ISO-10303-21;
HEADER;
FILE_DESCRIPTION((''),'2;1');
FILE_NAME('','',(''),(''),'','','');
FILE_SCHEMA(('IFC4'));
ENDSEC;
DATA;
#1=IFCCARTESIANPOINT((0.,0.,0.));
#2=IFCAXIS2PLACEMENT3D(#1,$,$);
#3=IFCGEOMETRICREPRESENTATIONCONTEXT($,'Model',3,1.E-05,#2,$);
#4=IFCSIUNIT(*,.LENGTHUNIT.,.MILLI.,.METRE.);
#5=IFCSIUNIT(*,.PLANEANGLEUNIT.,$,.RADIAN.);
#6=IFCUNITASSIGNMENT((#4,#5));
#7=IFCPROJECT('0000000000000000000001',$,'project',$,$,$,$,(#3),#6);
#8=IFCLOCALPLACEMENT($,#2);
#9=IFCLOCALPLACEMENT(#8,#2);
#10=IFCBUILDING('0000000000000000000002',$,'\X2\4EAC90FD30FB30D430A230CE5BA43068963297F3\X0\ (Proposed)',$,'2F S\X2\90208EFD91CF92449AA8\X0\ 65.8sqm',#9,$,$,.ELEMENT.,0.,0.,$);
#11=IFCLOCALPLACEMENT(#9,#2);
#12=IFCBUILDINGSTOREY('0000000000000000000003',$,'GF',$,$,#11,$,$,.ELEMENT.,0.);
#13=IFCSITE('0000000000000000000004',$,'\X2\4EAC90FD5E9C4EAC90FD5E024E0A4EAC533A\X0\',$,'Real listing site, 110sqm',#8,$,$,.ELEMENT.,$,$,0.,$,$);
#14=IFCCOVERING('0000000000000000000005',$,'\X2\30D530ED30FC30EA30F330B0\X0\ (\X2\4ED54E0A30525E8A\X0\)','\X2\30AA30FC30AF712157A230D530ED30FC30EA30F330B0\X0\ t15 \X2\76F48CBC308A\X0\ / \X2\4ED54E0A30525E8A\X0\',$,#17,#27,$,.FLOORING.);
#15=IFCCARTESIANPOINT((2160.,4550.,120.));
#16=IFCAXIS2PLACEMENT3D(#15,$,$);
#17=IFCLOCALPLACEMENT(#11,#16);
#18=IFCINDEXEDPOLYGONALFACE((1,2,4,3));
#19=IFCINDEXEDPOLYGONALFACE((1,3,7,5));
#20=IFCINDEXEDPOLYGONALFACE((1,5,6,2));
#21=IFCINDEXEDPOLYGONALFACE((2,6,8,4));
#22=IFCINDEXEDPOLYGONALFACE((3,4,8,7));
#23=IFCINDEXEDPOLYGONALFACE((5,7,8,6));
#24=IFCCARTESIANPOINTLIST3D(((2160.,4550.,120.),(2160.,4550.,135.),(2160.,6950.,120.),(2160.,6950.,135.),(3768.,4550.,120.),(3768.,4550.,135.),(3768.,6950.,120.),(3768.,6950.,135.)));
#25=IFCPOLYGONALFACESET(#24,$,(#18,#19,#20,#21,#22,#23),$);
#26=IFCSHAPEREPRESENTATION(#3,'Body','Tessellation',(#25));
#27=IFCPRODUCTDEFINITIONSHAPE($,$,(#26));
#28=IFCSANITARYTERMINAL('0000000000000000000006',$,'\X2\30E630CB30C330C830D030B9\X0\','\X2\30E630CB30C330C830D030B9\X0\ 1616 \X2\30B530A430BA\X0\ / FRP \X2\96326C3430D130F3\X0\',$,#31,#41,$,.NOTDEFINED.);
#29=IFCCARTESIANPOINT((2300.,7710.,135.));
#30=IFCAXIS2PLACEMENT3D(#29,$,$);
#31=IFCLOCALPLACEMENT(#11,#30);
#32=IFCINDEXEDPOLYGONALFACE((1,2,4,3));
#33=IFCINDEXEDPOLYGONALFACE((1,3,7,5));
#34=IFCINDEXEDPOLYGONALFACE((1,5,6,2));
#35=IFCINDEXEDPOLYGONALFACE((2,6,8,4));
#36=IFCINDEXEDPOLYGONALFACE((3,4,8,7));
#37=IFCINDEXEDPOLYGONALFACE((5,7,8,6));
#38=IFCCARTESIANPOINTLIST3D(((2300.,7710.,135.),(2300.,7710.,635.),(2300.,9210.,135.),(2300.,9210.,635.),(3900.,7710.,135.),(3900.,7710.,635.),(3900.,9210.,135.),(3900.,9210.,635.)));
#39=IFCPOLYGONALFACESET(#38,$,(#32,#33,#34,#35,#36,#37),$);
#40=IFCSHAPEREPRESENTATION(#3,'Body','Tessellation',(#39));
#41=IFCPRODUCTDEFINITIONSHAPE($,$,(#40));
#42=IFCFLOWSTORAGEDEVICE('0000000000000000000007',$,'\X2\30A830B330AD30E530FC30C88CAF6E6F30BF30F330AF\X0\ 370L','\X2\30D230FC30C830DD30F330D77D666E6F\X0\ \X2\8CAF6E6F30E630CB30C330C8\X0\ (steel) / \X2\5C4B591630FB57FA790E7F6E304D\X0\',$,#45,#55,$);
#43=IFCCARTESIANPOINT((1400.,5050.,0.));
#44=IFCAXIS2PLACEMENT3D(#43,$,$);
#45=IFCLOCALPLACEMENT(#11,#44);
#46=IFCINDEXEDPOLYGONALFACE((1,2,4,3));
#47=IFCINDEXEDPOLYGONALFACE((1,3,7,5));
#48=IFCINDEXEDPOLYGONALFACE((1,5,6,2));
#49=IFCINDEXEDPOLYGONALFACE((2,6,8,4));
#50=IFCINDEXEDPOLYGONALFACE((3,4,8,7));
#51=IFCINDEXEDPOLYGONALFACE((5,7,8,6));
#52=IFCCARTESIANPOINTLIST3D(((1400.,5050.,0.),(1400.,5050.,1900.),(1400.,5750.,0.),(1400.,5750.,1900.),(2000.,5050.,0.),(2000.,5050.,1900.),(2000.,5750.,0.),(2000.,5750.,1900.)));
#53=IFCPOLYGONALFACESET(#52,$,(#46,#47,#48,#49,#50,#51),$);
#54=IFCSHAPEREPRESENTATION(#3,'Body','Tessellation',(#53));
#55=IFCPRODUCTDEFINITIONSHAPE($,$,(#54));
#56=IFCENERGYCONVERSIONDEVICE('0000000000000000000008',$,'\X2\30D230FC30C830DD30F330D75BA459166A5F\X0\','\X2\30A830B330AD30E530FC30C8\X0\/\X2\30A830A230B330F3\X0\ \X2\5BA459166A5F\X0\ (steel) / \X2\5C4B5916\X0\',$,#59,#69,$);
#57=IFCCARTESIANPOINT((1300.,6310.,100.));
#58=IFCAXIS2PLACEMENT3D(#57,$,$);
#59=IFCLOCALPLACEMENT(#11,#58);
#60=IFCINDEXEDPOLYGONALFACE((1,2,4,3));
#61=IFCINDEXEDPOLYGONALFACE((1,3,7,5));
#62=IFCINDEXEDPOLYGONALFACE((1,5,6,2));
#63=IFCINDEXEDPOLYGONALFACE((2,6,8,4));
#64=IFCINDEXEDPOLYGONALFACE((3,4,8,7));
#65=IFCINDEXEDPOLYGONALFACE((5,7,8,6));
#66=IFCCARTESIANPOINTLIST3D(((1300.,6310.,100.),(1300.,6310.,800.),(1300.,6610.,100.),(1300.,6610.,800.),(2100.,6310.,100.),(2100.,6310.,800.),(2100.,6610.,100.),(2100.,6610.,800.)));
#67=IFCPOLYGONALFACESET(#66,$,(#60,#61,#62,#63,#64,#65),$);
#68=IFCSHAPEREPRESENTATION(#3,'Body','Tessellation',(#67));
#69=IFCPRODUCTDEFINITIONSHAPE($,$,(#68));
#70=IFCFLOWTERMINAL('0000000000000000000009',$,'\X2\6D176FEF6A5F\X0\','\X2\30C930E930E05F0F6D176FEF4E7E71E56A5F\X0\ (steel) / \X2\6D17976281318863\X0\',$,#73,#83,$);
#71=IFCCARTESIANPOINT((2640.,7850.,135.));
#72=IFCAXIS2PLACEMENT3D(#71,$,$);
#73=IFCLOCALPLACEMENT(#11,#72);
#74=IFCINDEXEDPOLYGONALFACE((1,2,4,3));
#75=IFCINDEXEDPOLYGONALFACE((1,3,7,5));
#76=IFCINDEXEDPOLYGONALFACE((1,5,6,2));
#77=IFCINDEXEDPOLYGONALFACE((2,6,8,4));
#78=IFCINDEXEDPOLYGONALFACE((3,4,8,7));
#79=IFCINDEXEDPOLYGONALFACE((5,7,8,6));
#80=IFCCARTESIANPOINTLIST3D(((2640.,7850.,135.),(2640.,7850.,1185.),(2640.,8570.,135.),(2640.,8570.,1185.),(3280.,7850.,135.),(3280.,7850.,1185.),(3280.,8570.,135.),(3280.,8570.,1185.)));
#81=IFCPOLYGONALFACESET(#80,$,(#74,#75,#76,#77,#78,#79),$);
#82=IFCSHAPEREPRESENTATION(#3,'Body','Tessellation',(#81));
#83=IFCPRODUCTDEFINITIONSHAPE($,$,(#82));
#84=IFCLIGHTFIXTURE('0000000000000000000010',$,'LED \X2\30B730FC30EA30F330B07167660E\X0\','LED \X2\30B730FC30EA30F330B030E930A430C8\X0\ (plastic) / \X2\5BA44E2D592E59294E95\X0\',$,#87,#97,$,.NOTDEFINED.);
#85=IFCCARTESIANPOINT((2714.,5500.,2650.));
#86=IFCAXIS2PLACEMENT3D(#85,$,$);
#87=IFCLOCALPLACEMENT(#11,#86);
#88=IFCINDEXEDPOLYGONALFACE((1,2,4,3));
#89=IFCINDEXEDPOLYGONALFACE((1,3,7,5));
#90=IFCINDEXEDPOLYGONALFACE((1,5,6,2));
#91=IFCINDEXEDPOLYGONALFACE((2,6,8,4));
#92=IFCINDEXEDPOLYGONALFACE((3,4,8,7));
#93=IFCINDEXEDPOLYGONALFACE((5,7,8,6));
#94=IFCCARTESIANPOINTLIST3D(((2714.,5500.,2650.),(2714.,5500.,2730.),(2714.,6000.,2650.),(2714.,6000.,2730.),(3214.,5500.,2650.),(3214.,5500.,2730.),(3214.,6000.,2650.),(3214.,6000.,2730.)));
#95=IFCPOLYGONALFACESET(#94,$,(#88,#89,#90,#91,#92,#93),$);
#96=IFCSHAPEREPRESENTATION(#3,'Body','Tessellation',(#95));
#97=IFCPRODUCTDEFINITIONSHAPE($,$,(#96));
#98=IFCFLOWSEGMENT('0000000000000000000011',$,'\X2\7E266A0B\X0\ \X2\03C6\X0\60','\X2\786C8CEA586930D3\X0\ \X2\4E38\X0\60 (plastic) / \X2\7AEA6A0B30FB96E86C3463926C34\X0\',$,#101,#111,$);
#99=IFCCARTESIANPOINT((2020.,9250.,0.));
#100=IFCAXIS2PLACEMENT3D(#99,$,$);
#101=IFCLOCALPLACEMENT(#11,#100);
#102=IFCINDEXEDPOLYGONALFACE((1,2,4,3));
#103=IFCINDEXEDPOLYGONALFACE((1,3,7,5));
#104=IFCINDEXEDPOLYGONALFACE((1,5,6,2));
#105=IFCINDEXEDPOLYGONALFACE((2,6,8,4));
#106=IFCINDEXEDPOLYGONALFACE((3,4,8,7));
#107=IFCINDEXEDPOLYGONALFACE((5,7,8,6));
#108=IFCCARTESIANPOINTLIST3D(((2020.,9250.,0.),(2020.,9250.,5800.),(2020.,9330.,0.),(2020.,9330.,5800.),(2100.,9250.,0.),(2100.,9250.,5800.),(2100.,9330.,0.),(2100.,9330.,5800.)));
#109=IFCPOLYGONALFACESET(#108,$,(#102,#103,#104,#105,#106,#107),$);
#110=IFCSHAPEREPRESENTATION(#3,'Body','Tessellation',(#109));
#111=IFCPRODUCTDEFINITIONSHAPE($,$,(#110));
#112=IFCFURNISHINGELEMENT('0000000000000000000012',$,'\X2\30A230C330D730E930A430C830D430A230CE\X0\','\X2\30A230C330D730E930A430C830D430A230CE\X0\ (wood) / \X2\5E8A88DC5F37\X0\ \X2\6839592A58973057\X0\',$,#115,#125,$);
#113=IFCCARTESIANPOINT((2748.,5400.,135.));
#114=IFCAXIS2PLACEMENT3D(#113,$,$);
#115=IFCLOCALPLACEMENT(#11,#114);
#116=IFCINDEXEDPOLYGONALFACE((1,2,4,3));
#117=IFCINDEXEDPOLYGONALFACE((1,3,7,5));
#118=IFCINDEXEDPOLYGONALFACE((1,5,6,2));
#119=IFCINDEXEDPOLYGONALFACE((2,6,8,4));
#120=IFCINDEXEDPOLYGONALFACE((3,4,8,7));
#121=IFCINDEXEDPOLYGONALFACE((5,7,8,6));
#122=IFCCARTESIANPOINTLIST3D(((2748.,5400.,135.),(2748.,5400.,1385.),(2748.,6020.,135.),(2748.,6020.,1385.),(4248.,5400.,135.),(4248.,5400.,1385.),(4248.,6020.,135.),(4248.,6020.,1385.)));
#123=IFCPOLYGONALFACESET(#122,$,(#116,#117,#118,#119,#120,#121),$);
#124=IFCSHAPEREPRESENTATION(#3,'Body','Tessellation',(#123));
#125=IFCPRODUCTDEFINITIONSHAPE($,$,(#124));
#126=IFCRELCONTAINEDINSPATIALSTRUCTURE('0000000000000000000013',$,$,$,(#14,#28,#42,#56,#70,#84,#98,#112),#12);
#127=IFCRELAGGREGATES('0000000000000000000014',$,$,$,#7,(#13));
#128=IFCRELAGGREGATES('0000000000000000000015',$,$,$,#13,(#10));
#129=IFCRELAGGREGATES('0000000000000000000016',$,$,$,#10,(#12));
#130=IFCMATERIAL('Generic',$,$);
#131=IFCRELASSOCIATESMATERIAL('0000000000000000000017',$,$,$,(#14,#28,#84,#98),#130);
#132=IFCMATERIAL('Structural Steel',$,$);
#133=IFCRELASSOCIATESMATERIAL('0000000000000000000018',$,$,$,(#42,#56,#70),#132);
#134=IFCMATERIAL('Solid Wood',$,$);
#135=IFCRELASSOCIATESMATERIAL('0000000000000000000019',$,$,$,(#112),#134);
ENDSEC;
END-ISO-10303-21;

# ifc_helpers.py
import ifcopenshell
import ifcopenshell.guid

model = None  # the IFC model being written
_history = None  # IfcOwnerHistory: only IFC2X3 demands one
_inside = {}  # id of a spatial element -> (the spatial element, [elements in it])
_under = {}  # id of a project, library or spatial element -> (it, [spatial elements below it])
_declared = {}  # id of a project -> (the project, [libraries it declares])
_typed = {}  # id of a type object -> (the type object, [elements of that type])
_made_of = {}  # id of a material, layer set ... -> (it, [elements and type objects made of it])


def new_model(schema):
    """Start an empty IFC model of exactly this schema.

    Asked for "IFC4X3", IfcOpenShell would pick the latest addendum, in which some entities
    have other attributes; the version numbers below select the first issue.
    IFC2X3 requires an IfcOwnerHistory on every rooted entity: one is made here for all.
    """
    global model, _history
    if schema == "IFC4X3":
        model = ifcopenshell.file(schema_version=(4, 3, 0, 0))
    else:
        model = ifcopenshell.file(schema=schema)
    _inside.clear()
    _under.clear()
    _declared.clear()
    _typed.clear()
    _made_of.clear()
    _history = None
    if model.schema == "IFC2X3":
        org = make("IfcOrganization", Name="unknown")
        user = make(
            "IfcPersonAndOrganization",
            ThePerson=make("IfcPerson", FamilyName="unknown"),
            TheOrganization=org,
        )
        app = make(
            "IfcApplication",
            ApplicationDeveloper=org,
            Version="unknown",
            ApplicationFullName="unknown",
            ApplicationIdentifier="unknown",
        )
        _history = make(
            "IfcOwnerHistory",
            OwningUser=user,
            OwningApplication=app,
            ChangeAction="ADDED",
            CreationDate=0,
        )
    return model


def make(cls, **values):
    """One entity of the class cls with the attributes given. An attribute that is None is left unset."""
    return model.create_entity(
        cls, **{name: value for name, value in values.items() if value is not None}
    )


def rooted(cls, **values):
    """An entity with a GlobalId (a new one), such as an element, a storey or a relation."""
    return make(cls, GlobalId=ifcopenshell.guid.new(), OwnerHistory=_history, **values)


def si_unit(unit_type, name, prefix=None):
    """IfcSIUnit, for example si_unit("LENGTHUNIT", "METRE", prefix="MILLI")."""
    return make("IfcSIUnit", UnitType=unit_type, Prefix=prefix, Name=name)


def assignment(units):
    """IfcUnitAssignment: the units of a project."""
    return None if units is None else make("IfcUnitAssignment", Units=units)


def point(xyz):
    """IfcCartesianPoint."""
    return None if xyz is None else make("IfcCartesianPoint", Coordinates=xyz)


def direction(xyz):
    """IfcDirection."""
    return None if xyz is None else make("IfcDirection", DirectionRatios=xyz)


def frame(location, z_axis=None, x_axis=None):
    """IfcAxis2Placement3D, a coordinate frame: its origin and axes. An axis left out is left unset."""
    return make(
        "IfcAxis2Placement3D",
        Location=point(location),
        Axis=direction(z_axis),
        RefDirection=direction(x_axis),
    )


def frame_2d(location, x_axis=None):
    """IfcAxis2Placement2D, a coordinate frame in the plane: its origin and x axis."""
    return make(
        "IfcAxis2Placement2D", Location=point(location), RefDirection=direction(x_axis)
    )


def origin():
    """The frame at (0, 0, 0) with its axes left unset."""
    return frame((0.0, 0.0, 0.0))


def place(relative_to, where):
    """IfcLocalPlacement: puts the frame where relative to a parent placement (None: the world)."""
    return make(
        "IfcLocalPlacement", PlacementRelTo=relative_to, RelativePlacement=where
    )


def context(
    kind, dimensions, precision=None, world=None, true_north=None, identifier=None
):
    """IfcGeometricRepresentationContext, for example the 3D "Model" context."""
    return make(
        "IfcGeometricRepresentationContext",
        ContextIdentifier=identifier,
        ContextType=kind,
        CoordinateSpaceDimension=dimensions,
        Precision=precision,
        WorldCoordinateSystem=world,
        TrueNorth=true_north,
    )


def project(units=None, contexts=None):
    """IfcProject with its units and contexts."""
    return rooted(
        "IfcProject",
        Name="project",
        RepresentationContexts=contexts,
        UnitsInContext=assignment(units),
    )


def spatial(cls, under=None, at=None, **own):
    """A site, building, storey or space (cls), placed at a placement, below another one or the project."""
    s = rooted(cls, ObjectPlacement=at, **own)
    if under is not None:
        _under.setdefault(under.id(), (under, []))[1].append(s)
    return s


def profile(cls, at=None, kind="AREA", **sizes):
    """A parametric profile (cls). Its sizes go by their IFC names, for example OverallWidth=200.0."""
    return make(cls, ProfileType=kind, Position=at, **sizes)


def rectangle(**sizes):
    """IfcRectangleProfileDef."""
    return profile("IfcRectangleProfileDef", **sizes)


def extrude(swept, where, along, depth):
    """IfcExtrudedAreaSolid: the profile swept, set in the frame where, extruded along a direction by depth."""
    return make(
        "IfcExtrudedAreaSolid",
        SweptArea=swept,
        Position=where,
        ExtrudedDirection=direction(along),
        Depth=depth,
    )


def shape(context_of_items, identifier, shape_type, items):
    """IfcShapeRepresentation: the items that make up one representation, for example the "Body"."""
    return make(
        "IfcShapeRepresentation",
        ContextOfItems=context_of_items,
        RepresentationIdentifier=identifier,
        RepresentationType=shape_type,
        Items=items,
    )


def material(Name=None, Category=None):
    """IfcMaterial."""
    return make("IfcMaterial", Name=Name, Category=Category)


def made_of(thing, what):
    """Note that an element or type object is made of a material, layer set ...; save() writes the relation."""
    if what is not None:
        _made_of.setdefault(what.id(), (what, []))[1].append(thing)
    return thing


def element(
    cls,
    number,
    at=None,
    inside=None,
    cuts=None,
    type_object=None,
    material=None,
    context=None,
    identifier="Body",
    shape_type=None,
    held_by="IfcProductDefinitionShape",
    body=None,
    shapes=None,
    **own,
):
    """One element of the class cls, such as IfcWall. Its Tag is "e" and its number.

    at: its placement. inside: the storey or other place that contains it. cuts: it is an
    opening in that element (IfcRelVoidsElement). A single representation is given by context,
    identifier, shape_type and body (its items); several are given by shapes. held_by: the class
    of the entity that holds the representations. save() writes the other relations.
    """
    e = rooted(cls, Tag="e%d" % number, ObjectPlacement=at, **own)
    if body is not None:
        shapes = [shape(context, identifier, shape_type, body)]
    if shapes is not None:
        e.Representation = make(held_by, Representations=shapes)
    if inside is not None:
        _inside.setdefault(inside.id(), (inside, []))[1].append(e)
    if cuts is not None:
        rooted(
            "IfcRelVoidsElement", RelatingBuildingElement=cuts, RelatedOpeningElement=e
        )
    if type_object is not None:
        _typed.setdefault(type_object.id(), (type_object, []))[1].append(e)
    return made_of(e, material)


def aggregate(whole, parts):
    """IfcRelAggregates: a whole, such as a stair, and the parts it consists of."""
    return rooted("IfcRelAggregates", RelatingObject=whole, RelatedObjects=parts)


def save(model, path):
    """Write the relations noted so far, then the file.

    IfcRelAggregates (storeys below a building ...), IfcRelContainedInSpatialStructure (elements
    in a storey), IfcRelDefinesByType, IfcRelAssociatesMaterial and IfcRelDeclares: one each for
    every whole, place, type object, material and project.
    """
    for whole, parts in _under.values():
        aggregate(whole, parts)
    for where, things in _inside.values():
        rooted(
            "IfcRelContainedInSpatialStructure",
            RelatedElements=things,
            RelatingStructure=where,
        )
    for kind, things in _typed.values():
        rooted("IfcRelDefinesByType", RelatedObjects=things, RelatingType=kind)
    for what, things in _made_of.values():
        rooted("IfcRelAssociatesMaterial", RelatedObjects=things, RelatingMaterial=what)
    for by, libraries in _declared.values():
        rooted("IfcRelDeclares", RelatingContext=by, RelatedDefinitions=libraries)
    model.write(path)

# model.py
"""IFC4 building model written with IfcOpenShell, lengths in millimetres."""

from ifc_helpers import new_model, si_unit, frame, frame_2d, origin, place, context, project, spatial, rectangle, extrude, material, element, save


model = new_model("IFC4")

# Units and contexts
model_context = context("Model", 3, precision=1e-05, world=origin())
ifc_project = project(units=[si_unit("LENGTHUNIT", "METRE", prefix="MILLI"), si_unit("PLANEANGLEUNIT", "RADIAN")], contexts=[model_context])

# Site, building, storey
site_placement = place(None, origin())
site = spatial("IfcSite", under=ifc_project, at=site_placement, Name="京都府京都市上京区", ObjectType="Real listing site, 110sqm", CompositionType="ELEMENT", RefElevation=0.0)
building_placement = place(site_placement, origin())
building = spatial("IfcBuilding", under=site, at=building_placement, Name="京都・ピアノ室と防音 (Proposed)", ObjectType="2F S造軽量鉄骨 65.8sqm", CompositionType="ELEMENT", ElevationOfRefHeight=0.0, ElevationOfTerrain=0.0)
storey_placement = place(building_placement, origin())
storey = spatial("IfcBuildingStorey", under=building, at=storey_placement, Name="GF", CompositionType="ELEMENT", Elevation=0.0)

# Shared definitions
ifc_material_1 = material(Name="Solid Wood")

# Covering
ifc_material_2 = material(Name="Generic")
covering_1_placement = place(storey_placement, frame((2160.0, 4550.0, 120.0)))
element("IfcCovering", 1, at=covering_1_placement, inside=storey, material=ifc_material_2, Name="フローリング (仕上げ床)", Description="オーク無垢フローリング t15 直貼り / 仕上げ床", PredefinedType="FLOORING", context=model_context, shape_type="SweptSolid", body=[
    extrude(rectangle(XDim=1608.0, YDim=2400.0, at=frame_2d((804.0, 1200.0))), frame((2160.0, 4550.0, 120.0)), (0.0, 0.0, 1.0), 15.0),
])

# Sanitary terminal
sanitary_terminal_placement = place(storey_placement, frame((2300.0, 7710.0, 135.0)))
element("IfcSanitaryTerminal", 2, at=sanitary_terminal_placement, inside=storey, material=ifc_material_2, Name="ユニットバス", Description="ユニットバス 1616 サイズ / FRP 防水パン", PredefinedType="NOTDEFINED", context=model_context, shape_type="SweptSolid", body=[
    extrude(rectangle(XDim=1600.0, YDim=1500.0, at=frame_2d((800.0, 750.0))), frame((2300.0, 7710.0, 135.0)), (0.0, 0.0, 1.0), 500.0),
])

# Flow storage device
ifc_material_3 = material(Name="Structural Steel")
flow_storage_device_placement = place(storey_placement, frame((1400.0, 5050.0, 0.0)))
element("IfcFlowStorageDevice", 3, at=flow_storage_device_placement, inside=storey, material=ifc_material_3, Name="エコキュート貯湯タンク 370L", Description="ヒートポンプ給湯 貯湯ユニット (steel) / 屋外・基礎置き", context=model_context, shape_type="SweptSolid", body=[
    extrude(rectangle(XDim=600.0, YDim=700.0, at=frame_2d((300.0, 350.0))), frame((1400.0, 5050.0, 0.0)), (0.0, 0.0, 1.0), 1900.0),
])

# Energy conversion device
energy_conversion_device_placement = place(storey_placement, frame((1300.0, 6310.0, 100.0)))
element("IfcEnergyConversionDevice", 4, at=energy_conversion_device_placement, inside=storey, material=ifc_material_3, Name="ヒートポンプ室外機", Description="エコキュート/エアコン 室外機 (steel) / 屋外", context=model_context, shape_type="SweptSolid", body=[
    extrude(rectangle(XDim=800.0, YDim=300.0, at=frame_2d((400.0, 150.0))), frame((1300.0, 6310.0, 100.0)), (0.0, 0.0, 1.0), 700.0),
])

# Flow terminal
flow_terminal_placement = place(storey_placement, frame((2640.0, 7850.0, 135.0)))
element("IfcFlowTerminal", 5, at=flow_terminal_placement, inside=storey, material=ifc_material_3, Name="洗濯機", Description="ドラム式洗濯乾燥機 (steel) / 洗面脱衣", context=model_context, shape_type="SweptSolid", body=[
    extrude(rectangle(XDim=640.0, YDim=720.0, at=frame_2d((320.0, 360.0))), frame((2640.0, 7850.0, 135.0)), (0.0, 0.0, 1.0), 1050.0),
])

# Light fixture
light_fixture_placement = place(storey_placement, frame((2714.0, 5500.0, 2650.0)))
element("IfcLightFixture", 6, at=light_fixture_placement, inside=storey, material=ifc_material_2, Name="LED シーリング照明", Description="LED シーリングライト (plastic) / 室中央天井", PredefinedType="NOTDEFINED", context=model_context, shape_type="SweptSolid", body=[
    extrude(rectangle(XDim=500.0, YDim=500.0, at=frame_2d((250.0, 250.0))), frame((2714.0, 5500.0, 2650.0)), (0.0, 0.0, 1.0), 80.0),
])

# Flow segment
flow_segment_placement = place(storey_placement, frame((2020.0, 9250.0, 0.0)))
element("IfcFlowSegment", 7, at=flow_segment_placement, inside=storey, material=ifc_material_2, Name="縦樋 φ60", Description="硬質塩ビ 丸60 (plastic) / 竪樋・雨水排水", context=model_context, shape_type="SweptSolid", body=[
    extrude(rectangle(XDim=80.0, YDim=80.0, at=frame_2d((40.0, 40.0))), frame((2020.0, 9250.0, 0.0)), (0.0, 0.0, 1.0), 5800.0),
])

# Furnishing element
furnishing_placement = place(storey_placement, frame((2748.0, 5400.0, 135.0)))
element("IfcFurnishingElement", 8, at=furnishing_placement, inside=storey, material=ifc_material_1, Name="アップライトピアノ", Description="アップライトピアノ (wood) / 床補強 根太増し", context=model_context, shape_type="SweptSolid", body=[
    extrude(rectangle(XDim=1500.0, YDim=620.0, at=frame_2d((750.0, 310.0))), frame((2748.0, 5400.0, 135.0)), (0.0, 0.0, 1.0), 1250.0),
])

save(model, "model.ifc")
